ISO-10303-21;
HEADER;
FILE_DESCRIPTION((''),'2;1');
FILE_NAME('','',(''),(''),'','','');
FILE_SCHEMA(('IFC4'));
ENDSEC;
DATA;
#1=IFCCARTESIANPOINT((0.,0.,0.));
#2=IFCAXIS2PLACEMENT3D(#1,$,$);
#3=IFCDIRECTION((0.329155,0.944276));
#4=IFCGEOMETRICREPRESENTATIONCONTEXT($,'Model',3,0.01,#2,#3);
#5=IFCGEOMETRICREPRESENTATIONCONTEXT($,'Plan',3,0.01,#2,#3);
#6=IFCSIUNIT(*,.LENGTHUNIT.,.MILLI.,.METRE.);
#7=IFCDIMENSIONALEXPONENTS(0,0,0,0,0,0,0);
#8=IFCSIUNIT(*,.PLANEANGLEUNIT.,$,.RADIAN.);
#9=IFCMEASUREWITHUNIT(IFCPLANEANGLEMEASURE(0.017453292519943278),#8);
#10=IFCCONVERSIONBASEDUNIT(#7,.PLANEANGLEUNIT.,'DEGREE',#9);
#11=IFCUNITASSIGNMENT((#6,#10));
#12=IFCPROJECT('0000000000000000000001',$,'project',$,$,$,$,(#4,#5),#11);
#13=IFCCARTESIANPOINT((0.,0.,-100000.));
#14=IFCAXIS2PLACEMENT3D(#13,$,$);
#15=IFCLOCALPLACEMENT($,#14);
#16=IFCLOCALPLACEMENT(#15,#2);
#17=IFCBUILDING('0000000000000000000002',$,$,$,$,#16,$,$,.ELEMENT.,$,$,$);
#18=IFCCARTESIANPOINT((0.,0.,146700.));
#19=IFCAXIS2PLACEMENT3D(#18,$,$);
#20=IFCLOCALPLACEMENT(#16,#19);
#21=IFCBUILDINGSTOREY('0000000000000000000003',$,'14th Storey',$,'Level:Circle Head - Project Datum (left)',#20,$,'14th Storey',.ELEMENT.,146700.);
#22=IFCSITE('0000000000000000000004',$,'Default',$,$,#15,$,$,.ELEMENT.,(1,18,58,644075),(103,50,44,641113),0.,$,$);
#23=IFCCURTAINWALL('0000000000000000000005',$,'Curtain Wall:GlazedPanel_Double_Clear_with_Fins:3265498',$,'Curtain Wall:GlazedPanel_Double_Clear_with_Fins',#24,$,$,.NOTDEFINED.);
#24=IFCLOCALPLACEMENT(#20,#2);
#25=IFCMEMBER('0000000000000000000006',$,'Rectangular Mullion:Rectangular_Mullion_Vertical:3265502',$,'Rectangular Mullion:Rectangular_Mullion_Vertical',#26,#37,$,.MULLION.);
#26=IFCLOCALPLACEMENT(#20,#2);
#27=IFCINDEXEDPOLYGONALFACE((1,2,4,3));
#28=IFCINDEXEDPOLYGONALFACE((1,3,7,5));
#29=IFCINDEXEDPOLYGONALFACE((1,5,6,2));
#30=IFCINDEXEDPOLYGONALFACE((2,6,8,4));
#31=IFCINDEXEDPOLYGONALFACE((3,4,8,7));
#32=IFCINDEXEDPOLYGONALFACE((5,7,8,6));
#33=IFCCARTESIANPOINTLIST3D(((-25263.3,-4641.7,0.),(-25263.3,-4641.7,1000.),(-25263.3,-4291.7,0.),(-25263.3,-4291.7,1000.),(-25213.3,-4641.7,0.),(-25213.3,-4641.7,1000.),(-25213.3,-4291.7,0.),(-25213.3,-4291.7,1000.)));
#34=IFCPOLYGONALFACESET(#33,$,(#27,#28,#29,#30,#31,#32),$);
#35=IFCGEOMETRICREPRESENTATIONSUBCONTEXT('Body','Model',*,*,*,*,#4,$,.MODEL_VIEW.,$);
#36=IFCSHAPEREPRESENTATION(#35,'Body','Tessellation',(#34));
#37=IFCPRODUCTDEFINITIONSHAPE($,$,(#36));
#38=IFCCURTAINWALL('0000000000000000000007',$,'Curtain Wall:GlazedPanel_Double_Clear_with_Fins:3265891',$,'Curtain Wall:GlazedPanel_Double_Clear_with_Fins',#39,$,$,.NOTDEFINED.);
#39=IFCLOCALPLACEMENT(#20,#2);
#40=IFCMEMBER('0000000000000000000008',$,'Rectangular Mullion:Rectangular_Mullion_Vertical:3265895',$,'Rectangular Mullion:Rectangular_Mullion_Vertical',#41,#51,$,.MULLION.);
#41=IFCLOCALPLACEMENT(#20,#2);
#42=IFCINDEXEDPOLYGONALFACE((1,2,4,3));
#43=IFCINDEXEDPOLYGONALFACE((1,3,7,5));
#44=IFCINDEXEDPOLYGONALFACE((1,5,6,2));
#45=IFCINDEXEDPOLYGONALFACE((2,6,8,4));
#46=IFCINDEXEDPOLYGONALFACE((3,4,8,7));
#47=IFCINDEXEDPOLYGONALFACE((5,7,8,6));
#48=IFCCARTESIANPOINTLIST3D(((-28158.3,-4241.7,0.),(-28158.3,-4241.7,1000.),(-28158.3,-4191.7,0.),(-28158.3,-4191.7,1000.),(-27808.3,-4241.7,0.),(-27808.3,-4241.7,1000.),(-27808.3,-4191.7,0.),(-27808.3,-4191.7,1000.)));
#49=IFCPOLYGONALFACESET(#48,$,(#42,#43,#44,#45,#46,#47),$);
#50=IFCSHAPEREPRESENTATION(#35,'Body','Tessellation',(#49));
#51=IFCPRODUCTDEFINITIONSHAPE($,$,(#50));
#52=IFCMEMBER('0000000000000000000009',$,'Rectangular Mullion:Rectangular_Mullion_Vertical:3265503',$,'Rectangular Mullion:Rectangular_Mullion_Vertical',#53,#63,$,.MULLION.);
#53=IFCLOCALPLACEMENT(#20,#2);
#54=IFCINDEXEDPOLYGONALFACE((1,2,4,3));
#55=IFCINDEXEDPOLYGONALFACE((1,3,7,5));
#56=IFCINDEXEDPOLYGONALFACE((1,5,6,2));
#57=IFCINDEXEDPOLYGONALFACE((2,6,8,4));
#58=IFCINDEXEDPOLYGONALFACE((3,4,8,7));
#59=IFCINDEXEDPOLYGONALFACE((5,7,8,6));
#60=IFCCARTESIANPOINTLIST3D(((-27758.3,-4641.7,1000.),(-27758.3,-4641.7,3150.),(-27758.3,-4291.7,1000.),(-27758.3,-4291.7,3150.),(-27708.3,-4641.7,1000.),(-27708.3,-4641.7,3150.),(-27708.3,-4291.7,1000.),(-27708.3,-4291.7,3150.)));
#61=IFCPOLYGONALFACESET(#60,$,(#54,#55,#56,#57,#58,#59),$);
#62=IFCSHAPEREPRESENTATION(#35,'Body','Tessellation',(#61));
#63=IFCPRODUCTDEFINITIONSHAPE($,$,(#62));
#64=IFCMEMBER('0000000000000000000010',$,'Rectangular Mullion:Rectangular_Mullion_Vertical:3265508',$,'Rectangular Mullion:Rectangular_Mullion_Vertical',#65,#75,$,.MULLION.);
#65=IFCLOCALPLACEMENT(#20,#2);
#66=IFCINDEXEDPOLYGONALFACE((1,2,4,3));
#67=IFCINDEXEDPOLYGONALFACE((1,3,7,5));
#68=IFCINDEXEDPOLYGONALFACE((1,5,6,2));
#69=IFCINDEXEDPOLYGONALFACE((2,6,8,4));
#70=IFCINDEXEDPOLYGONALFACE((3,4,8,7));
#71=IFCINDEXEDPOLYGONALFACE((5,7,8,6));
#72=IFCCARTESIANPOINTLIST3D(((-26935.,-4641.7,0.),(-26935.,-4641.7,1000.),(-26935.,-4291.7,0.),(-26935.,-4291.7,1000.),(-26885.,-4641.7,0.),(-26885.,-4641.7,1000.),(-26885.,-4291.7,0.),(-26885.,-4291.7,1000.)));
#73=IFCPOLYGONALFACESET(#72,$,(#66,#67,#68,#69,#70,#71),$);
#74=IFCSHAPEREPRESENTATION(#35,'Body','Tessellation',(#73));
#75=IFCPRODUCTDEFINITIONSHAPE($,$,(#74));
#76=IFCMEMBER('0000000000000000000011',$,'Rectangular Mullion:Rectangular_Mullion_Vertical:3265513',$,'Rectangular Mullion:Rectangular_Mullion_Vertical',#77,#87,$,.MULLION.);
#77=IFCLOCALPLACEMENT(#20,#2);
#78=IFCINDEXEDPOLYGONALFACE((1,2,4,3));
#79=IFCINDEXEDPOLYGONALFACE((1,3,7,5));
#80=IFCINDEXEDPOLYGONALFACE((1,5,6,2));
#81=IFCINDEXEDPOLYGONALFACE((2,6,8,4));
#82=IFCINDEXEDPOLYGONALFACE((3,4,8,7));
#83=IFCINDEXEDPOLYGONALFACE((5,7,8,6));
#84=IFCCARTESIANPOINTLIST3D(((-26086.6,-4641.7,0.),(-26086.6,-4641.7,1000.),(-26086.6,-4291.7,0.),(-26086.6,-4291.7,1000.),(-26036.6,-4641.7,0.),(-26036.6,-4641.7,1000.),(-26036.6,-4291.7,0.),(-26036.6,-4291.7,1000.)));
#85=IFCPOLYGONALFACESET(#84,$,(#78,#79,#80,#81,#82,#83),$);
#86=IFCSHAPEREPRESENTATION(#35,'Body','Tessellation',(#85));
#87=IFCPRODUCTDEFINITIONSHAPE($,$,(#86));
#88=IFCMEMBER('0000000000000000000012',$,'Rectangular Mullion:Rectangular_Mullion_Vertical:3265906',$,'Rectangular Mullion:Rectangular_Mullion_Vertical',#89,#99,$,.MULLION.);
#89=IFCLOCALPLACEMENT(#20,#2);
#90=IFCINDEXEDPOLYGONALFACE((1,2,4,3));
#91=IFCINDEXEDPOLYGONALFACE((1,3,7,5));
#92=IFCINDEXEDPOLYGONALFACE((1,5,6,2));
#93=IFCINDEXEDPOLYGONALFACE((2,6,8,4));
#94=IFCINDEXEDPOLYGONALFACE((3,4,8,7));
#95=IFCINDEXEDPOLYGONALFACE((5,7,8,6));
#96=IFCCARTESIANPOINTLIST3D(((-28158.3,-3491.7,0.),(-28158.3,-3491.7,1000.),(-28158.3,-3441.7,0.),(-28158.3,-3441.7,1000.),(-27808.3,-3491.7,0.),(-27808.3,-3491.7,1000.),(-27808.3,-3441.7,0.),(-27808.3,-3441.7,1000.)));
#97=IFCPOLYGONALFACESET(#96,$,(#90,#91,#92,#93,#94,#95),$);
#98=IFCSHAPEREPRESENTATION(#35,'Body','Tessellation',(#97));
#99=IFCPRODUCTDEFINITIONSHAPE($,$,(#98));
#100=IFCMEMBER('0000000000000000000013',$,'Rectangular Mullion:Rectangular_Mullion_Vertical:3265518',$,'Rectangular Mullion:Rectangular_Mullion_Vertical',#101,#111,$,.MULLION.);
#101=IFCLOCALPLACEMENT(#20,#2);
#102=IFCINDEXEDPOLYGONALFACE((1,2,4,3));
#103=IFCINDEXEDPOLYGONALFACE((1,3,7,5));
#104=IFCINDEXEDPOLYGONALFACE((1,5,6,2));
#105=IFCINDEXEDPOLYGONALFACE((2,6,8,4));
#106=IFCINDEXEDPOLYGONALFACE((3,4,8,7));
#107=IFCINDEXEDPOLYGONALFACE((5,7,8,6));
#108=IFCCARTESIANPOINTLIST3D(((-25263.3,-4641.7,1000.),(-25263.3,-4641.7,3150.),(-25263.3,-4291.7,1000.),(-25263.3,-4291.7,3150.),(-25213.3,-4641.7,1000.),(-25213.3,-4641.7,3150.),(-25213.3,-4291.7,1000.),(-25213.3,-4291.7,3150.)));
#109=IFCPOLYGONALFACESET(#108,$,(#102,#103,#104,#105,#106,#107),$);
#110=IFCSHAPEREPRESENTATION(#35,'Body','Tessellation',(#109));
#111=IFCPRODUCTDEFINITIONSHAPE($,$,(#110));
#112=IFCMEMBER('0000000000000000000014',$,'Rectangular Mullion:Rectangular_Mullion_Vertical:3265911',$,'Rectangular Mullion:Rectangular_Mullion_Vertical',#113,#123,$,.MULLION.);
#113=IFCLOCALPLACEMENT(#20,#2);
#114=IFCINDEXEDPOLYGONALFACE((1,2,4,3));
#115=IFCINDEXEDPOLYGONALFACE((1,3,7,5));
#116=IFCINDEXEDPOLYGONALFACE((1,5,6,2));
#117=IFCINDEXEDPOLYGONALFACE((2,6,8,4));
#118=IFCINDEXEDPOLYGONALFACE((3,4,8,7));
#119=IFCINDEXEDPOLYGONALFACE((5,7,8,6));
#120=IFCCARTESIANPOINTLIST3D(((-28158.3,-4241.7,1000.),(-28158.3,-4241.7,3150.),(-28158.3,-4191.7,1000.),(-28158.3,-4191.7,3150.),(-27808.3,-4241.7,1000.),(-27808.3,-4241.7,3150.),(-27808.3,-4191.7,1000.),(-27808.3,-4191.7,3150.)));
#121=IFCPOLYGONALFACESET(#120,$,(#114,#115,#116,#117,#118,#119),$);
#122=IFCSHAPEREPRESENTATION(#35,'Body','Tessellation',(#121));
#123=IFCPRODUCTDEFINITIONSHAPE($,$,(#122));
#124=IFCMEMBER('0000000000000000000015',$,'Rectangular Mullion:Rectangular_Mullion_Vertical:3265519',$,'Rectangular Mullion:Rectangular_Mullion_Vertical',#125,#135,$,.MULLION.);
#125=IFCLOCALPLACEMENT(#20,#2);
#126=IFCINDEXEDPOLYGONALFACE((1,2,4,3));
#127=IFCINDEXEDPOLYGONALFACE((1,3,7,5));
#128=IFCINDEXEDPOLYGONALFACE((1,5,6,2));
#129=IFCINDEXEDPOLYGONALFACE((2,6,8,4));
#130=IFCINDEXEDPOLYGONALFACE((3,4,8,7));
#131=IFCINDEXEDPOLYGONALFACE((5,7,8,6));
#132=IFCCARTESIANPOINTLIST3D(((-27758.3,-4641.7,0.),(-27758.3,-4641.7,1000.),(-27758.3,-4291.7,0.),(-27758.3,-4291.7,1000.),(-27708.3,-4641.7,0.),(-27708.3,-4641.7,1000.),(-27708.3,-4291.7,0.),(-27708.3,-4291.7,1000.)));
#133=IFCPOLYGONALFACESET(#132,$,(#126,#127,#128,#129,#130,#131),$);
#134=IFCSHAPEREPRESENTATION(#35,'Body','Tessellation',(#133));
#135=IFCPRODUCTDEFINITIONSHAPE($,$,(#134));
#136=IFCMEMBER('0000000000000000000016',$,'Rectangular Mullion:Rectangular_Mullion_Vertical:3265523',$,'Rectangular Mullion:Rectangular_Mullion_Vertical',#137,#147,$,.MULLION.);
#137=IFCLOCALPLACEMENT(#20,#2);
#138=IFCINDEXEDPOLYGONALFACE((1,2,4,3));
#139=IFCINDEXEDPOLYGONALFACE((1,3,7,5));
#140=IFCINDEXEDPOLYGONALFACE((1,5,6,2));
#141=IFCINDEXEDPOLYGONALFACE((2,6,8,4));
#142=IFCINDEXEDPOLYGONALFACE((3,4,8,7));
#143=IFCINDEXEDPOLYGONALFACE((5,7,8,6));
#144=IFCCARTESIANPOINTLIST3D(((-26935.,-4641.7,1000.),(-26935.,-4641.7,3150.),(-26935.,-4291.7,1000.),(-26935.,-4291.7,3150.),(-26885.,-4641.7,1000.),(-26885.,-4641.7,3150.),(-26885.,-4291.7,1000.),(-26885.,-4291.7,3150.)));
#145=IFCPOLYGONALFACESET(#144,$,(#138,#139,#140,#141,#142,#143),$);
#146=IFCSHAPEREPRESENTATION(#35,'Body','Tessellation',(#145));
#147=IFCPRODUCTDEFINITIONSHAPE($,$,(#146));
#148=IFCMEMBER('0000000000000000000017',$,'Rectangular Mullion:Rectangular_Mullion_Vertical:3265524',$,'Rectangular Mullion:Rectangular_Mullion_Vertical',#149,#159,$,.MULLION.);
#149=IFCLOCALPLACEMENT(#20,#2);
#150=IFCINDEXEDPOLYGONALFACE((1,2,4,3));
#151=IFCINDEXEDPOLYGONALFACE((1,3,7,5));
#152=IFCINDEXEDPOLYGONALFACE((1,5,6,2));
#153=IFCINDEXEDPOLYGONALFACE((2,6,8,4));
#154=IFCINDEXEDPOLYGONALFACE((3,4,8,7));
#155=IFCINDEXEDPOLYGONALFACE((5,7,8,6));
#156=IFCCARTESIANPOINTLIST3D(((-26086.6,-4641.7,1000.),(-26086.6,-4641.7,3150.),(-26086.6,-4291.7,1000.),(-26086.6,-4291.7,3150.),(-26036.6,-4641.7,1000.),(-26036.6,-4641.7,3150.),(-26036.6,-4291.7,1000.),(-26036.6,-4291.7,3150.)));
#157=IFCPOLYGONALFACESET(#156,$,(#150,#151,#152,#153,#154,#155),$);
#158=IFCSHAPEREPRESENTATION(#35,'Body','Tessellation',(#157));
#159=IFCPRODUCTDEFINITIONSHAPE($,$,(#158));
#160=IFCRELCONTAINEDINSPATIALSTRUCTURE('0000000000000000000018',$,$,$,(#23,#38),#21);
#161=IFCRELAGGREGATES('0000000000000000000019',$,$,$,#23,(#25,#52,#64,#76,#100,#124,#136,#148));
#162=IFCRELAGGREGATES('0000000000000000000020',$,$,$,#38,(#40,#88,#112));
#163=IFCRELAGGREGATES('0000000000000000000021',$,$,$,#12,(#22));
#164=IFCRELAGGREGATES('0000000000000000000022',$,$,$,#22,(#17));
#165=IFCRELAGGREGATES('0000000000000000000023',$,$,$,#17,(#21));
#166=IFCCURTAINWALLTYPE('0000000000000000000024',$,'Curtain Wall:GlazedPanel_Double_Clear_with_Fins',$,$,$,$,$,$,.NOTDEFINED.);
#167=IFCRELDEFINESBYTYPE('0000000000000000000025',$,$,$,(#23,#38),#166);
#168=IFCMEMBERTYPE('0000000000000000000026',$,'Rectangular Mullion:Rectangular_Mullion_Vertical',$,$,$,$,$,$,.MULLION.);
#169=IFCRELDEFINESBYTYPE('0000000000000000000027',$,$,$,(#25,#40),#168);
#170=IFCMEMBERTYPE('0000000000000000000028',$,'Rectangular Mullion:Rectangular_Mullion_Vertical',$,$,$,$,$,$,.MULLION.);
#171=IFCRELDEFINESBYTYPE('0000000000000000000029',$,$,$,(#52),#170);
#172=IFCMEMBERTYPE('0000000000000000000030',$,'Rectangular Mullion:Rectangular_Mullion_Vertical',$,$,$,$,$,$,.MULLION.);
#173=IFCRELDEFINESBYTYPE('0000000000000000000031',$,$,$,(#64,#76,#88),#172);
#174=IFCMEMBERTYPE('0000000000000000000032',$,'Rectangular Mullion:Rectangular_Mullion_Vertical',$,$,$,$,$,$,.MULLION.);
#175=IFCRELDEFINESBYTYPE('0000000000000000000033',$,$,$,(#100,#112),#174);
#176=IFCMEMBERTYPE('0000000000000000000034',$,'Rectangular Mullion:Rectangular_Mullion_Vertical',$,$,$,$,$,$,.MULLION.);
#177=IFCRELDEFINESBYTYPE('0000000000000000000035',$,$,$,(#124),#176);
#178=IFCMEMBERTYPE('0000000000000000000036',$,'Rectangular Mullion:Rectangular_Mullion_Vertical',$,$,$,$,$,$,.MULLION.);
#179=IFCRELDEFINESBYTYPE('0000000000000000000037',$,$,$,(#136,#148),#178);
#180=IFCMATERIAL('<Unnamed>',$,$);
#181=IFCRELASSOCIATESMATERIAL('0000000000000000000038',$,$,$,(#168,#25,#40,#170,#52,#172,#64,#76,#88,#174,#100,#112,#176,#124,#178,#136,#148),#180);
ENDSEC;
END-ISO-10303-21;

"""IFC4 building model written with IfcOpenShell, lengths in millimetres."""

from ifc_helpers import new_model, entity, si_unit, converted_unit, direction, frame, origin, place, context, subcontext, project, spatial, indexed_curve, outline, extrude, source, transform, mapped, material, type_object, type_shapes, element, aggregate, save


model = new_model("IFC4")

# Units and contexts
model_context = context("Model", 3, precision=0.01, world=origin(), true_north=direction((0.329155, 0.944276)))
plan_context = context("Plan", 3, precision=0.01, world=origin(), true_north=direction((0.329155, 0.944276)))
body_context = subcontext(model_context, "Body", "Model", "MODEL_VIEW")
ifc_project = project(units=[si_unit("LENGTHUNIT", "METRE", prefix="MILLI"), converted_unit("PLANEANGLEUNIT", "DEGREE", entity("IfcPlaneAngleMeasure", 0.017453292519943278), si_unit("PLANEANGLEUNIT", "RADIAN"), dimensions=[0, 0, 0, 0, 0, 0, 0])], contexts=[model_context, plan_context])

# Site, building, storey
site_placement = place(None, frame((0.0, 0.0, -100000.0)))
site = spatial("IfcSite", under=ifc_project, at=site_placement, Name="Default", CompositionType="ELEMENT", RefLatitude=(1, 18, 58, 644075), RefLongitude=(103, 50, 44, 641113), RefElevation=0.0)
building_placement = place(site_placement, origin())
building = spatial("IfcBuilding", under=site, at=building_placement, CompositionType="ELEMENT")
storey_placement = place(building_placement, frame((0.0, 0.0, 146700.0)))
storey = spatial("IfcBuildingStorey", under=building, at=storey_placement, Name="14th Storey", ObjectType="Level:Circle Head - Project Datum (left)", LongName="14th Storey", CompositionType="ELEMENT", Elevation=146700.0)

# Curtain walls, members
curtain_wall_type = type_object("IfcCurtainWallType", Name="Curtain Wall:GlazedPanel_Double_Clear_with_Fins", PredefinedType="NOTDEFINED")
curtain_wall_1_placement = place(storey_placement, frame((0.0, 0.0, -146700.0)))
curtain_wall_1 = element("IfcCurtainWall", 1, at=curtain_wall_1_placement, inside=storey, type_object=curtain_wall_type, Name="Curtain Wall:GlazedPanel_Double_Clear_with_Fins:3265498", ObjectType="Curtain Wall:GlazedPanel_Double_Clear_with_Fins", PredefinedType="NOTDEFINED")
ifc_material_1 = material(Name="<Unnamed>")
member_type_1 = type_object("IfcMemberType", Name="Rectangular Mullion:Rectangular_Mullion_Vertical", PredefinedType="MULLION", material=ifc_material_1)
shared_shape_1 = source(origin(), body_context, "Body", "SweptSolid", [
    extrude(outline(indexed_curve([(-25.0, -175.0), (25.0, -175.0), (25.0, 175.0), (-25.0, 175.0), (-25.0, -175.0)], self_intersect=False)), frame((-25.0, 50.0, -1000.0), z_axis=(0.0, 0.0, 1.0), x_axis=(-1.0, 0.0, 0.0)), (0.0, 0.0, 1.0), 1000.0),
])
type_shapes(member_type_1, [shared_shape_1])
member_1_placement = place(curtain_wall_1_placement, frame((-25213.3, -4416.7, 146700.0), z_axis=(0.0, 0.0, -1.0), x_axis=(1.0, 0.0, 0.0)))
member_1 = element("IfcMember", 2, at=member_1_placement, type_object=member_type_1, material=ifc_material_1, Name="Rectangular Mullion:Rectangular_Mullion_Vertical:3265502", ObjectType="Rectangular Mullion:Rectangular_Mullion_Vertical", PredefinedType="MULLION", context=body_context, shape_type="MappedRepresentation", body=[
    mapped(shared_shape_1, transform((0.0, 0.0, 0.0), scale=1.0)),
])
curtain_wall_2_placement = place(storey_placement, frame((0.0, 0.0, -146700.0)))
curtain_wall_2 = element("IfcCurtainWall", 3, at=curtain_wall_2_placement, inside=storey, type_object=curtain_wall_type, Name="Curtain Wall:GlazedPanel_Double_Clear_with_Fins:3265891", ObjectType="Curtain Wall:GlazedPanel_Double_Clear_with_Fins", PredefinedType="NOTDEFINED")
member_2_placement = place(curtain_wall_2_placement, frame((-27933.3, -4241.7, 146700.0), z_axis=(0.0, 0.0, -1.0), x_axis=(0.0, -1.0, 0.0)))
member_2 = element("IfcMember", 4, at=member_2_placement, type_object=member_type_1, material=ifc_material_1, Name="Rectangular Mullion:Rectangular_Mullion_Vertical:3265895", ObjectType="Rectangular Mullion:Rectangular_Mullion_Vertical", PredefinedType="MULLION", context=body_context, shape_type="MappedRepresentation", body=[
    mapped(shared_shape_1, transform((0.0, 0.0, 0.0), scale=1.0)),
])

# Members
member_type_2 = type_object("IfcMemberType", Name="Rectangular Mullion:Rectangular_Mullion_Vertical", PredefinedType="MULLION", material=ifc_material_1)
shared_shape_2 = source(origin(), body_context, "Body", "SweptSolid", [
    extrude(outline(indexed_curve([(-25.0, -175.0), (25.0, -175.0), (25.0, 175.0), (-25.0, 175.0), (-25.0, -175.0)], self_intersect=False)), frame((-25.0, 50.0, -2150.0), z_axis=(0.0, 0.0, 1.0), x_axis=(-1.0, 0.0, 0.0)), (0.0, 0.0, 1.0), 2150.0),
])
type_shapes(member_type_2, [shared_shape_2])
member_3_placement = place(curtain_wall_1_placement, frame((-27758.3, -4416.7, 149850.0), z_axis=(0.0, 0.0, 1.0), x_axis=(-1.0, 0.0, 0.0)))
member_3 = element("IfcMember", 5, at=member_3_placement, type_object=member_type_2, material=ifc_material_1, Name="Rectangular Mullion:Rectangular_Mullion_Vertical:3265503", ObjectType="Rectangular Mullion:Rectangular_Mullion_Vertical", PredefinedType="MULLION", context=body_context, shape_type="MappedRepresentation", body=[
    mapped(shared_shape_2, transform((0.0, 0.0, 0.0), scale=1.0)),
])
member_type_3 = type_object("IfcMemberType", Name="Rectangular Mullion:Rectangular_Mullion_Vertical", PredefinedType="MULLION", material=ifc_material_1)
shared_shape_3 = source(origin(), body_context, "Body", "SweptSolid", [
    extrude(outline(indexed_curve([(-25.0, -175.0), (25.0, -175.0), (25.0, 175.0), (-25.0, 175.0), (-25.0, -175.0)], self_intersect=False)), frame((0.0, 50.0, -1000.0), z_axis=(0.0, 0.0, 1.0), x_axis=(-1.0, 0.0, 0.0)), (0.0, 0.0, 1.0), 1000.0),
])
type_shapes(member_type_3, [shared_shape_3])
member_4_placement = place(curtain_wall_1_placement, frame((-26910.0, -4416.7, 146700.0), z_axis=(0.0, 0.0, -1.0), x_axis=(1.0, 0.0, 0.0)))
member_4 = element("IfcMember", 6, at=member_4_placement, type_object=member_type_3, material=ifc_material_1, Name="Rectangular Mullion:Rectangular_Mullion_Vertical:3265508", ObjectType="Rectangular Mullion:Rectangular_Mullion_Vertical", PredefinedType="MULLION", context=body_context, shape_type="MappedRepresentation", body=[
    mapped(shared_shape_3, transform((0.0, 0.0, 0.0), scale=1.0)),
])
member_5_placement = place(curtain_wall_1_placement, frame((-26061.6, -4416.7, 146700.0), z_axis=(0.0, 0.0, -1.0), x_axis=(1.0, 0.0, 0.0)))
member_5 = element("IfcMember", 7, at=member_5_placement, type_object=member_type_3, material=ifc_material_1, Name="Rectangular Mullion:Rectangular_Mullion_Vertical:3265513", ObjectType="Rectangular Mullion:Rectangular_Mullion_Vertical", PredefinedType="MULLION", context=body_context, shape_type="MappedRepresentation", body=[
    mapped(shared_shape_3, transform((0.0, 0.0, 0.0), scale=1.0)),
])
member_6_placement = place(curtain_wall_2_placement, frame((-27933.3, -3466.7, 146700.0), z_axis=(0.0, 0.0, -1.0), x_axis=(0.0, -1.0, 0.0)))
member_6 = element("IfcMember", 8, at=member_6_placement, type_object=member_type_3, material=ifc_material_1, Name="Rectangular Mullion:Rectangular_Mullion_Vertical:3265906", ObjectType="Rectangular Mullion:Rectangular_Mullion_Vertical", PredefinedType="MULLION", context=body_context, shape_type="MappedRepresentation", body=[
    mapped(shared_shape_3, transform((0.0, 0.0, 0.0), scale=1.0)),
])
member_type_4 = type_object("IfcMemberType", Name="Rectangular Mullion:Rectangular_Mullion_Vertical", PredefinedType="MULLION", material=ifc_material_1)
shared_shape_4 = source(origin(), body_context, "Body", "SweptSolid", [
    extrude(outline(indexed_curve([(-25.0, -175.0), (25.0, -175.0), (25.0, 175.0), (-25.0, 175.0), (-25.0, -175.0)], self_intersect=False)), frame((-25.0, 50.0, -2150.0), z_axis=(0.0, 0.0, 1.0), x_axis=(-1.0, 0.0, 0.0)), (0.0, 0.0, 1.0), 2150.0),
])
type_shapes(member_type_4, [shared_shape_4])
member_7_placement = place(curtain_wall_1_placement, frame((-25213.3, -4416.7, 147700.0), z_axis=(0.0, 0.0, -1.0), x_axis=(1.0, 0.0, 0.0)))
member_7 = element("IfcMember", 9, at=member_7_placement, type_object=member_type_4, material=ifc_material_1, Name="Rectangular Mullion:Rectangular_Mullion_Vertical:3265518", ObjectType="Rectangular Mullion:Rectangular_Mullion_Vertical", PredefinedType="MULLION", context=body_context, shape_type="MappedRepresentation", body=[
    mapped(shared_shape_4, transform((0.0, 0.0, 0.0), scale=1.0)),
])
member_8_placement = place(curtain_wall_2_placement, frame((-27933.3, -4241.7, 147700.0), z_axis=(0.0, 0.0, -1.0), x_axis=(0.0, -1.0, 0.0)))
member_8 = element("IfcMember", 10, at=member_8_placement, type_object=member_type_4, material=ifc_material_1, Name="Rectangular Mullion:Rectangular_Mullion_Vertical:3265911", ObjectType="Rectangular Mullion:Rectangular_Mullion_Vertical", PredefinedType="MULLION", context=body_context, shape_type="MappedRepresentation", body=[
    mapped(shared_shape_4, transform((0.0, 0.0, 0.0), scale=1.0)),
])
member_type_5 = type_object("IfcMemberType", Name="Rectangular Mullion:Rectangular_Mullion_Vertical", PredefinedType="MULLION", material=ifc_material_1)
shared_shape_5 = source(origin(), body_context, "Body", "SweptSolid", [
    extrude(outline(indexed_curve([(-25.0, -175.0), (25.0, -175.0), (25.0, 175.0), (-25.0, 175.0), (-25.0, -175.0)], self_intersect=False)), frame((-25.0, 50.0, -1000.0), z_axis=(0.0, 0.0, 1.0), x_axis=(-1.0, 0.0, 0.0)), (0.0, 0.0, 1.0), 1000.0),
])
type_shapes(member_type_5, [shared_shape_5])
member_9_placement = place(curtain_wall_1_placement, frame((-27758.3, -4416.7, 147700.0), z_axis=(0.0, 0.0, 1.0), x_axis=(-1.0, 0.0, 0.0)))
member_9 = element("IfcMember", 11, at=member_9_placement, type_object=member_type_5, material=ifc_material_1, Name="Rectangular Mullion:Rectangular_Mullion_Vertical:3265519", ObjectType="Rectangular Mullion:Rectangular_Mullion_Vertical", PredefinedType="MULLION", context=body_context, shape_type="MappedRepresentation", body=[
    mapped(shared_shape_5, transform((0.0, 0.0, 0.0), scale=1.0)),
])
member_type_6 = type_object("IfcMemberType", Name="Rectangular Mullion:Rectangular_Mullion_Vertical", PredefinedType="MULLION", material=ifc_material_1)
shared_shape_6 = source(origin(), body_context, "Body", "SweptSolid", [
    extrude(outline(indexed_curve([(-25.0, -175.0), (25.0, -175.0), (25.0, 175.0), (-25.0, 175.0), (-25.0, -175.0)], self_intersect=False)), frame((0.0, 50.0, -2150.0), z_axis=(0.0, 0.0, 1.0), x_axis=(-1.0, 0.0, 0.0)), (0.0, 0.0, 1.0), 2150.0),
])
type_shapes(member_type_6, [shared_shape_6])
member_10_placement = place(curtain_wall_1_placement, frame((-26910.0, -4416.7, 147700.0), z_axis=(0.0, 0.0, -1.0), x_axis=(1.0, 0.0, 0.0)))
member_10 = element("IfcMember", 12, at=member_10_placement, type_object=member_type_6, material=ifc_material_1, Name="Rectangular Mullion:Rectangular_Mullion_Vertical:3265523", ObjectType="Rectangular Mullion:Rectangular_Mullion_Vertical", PredefinedType="MULLION", context=body_context, shape_type="MappedRepresentation", body=[
    mapped(shared_shape_6, transform((0.0, 0.0, 0.0), scale=1.0)),
])
member_11_placement = place(curtain_wall_1_placement, frame((-26061.6, -4416.7, 147700.0), z_axis=(0.0, 0.0, -1.0), x_axis=(1.0, 0.0, 0.0)))
member_11 = element("IfcMember", 13, at=member_11_placement, type_object=member_type_6, material=ifc_material_1, Name="Rectangular Mullion:Rectangular_Mullion_Vertical:3265524", ObjectType="Rectangular Mullion:Rectangular_Mullion_Vertical", PredefinedType="MULLION", context=body_context, shape_type="MappedRepresentation", body=[
    mapped(shared_shape_6, transform((0.0, 0.0, 0.0), scale=1.0)),
])

aggregate(curtain_wall_1, [member_1, member_3, member_4, member_5, member_7, member_9, member_10, member_11])
aggregate(curtain_wall_2, [member_2, member_6, member_8])

save(model, "model.ifc")
